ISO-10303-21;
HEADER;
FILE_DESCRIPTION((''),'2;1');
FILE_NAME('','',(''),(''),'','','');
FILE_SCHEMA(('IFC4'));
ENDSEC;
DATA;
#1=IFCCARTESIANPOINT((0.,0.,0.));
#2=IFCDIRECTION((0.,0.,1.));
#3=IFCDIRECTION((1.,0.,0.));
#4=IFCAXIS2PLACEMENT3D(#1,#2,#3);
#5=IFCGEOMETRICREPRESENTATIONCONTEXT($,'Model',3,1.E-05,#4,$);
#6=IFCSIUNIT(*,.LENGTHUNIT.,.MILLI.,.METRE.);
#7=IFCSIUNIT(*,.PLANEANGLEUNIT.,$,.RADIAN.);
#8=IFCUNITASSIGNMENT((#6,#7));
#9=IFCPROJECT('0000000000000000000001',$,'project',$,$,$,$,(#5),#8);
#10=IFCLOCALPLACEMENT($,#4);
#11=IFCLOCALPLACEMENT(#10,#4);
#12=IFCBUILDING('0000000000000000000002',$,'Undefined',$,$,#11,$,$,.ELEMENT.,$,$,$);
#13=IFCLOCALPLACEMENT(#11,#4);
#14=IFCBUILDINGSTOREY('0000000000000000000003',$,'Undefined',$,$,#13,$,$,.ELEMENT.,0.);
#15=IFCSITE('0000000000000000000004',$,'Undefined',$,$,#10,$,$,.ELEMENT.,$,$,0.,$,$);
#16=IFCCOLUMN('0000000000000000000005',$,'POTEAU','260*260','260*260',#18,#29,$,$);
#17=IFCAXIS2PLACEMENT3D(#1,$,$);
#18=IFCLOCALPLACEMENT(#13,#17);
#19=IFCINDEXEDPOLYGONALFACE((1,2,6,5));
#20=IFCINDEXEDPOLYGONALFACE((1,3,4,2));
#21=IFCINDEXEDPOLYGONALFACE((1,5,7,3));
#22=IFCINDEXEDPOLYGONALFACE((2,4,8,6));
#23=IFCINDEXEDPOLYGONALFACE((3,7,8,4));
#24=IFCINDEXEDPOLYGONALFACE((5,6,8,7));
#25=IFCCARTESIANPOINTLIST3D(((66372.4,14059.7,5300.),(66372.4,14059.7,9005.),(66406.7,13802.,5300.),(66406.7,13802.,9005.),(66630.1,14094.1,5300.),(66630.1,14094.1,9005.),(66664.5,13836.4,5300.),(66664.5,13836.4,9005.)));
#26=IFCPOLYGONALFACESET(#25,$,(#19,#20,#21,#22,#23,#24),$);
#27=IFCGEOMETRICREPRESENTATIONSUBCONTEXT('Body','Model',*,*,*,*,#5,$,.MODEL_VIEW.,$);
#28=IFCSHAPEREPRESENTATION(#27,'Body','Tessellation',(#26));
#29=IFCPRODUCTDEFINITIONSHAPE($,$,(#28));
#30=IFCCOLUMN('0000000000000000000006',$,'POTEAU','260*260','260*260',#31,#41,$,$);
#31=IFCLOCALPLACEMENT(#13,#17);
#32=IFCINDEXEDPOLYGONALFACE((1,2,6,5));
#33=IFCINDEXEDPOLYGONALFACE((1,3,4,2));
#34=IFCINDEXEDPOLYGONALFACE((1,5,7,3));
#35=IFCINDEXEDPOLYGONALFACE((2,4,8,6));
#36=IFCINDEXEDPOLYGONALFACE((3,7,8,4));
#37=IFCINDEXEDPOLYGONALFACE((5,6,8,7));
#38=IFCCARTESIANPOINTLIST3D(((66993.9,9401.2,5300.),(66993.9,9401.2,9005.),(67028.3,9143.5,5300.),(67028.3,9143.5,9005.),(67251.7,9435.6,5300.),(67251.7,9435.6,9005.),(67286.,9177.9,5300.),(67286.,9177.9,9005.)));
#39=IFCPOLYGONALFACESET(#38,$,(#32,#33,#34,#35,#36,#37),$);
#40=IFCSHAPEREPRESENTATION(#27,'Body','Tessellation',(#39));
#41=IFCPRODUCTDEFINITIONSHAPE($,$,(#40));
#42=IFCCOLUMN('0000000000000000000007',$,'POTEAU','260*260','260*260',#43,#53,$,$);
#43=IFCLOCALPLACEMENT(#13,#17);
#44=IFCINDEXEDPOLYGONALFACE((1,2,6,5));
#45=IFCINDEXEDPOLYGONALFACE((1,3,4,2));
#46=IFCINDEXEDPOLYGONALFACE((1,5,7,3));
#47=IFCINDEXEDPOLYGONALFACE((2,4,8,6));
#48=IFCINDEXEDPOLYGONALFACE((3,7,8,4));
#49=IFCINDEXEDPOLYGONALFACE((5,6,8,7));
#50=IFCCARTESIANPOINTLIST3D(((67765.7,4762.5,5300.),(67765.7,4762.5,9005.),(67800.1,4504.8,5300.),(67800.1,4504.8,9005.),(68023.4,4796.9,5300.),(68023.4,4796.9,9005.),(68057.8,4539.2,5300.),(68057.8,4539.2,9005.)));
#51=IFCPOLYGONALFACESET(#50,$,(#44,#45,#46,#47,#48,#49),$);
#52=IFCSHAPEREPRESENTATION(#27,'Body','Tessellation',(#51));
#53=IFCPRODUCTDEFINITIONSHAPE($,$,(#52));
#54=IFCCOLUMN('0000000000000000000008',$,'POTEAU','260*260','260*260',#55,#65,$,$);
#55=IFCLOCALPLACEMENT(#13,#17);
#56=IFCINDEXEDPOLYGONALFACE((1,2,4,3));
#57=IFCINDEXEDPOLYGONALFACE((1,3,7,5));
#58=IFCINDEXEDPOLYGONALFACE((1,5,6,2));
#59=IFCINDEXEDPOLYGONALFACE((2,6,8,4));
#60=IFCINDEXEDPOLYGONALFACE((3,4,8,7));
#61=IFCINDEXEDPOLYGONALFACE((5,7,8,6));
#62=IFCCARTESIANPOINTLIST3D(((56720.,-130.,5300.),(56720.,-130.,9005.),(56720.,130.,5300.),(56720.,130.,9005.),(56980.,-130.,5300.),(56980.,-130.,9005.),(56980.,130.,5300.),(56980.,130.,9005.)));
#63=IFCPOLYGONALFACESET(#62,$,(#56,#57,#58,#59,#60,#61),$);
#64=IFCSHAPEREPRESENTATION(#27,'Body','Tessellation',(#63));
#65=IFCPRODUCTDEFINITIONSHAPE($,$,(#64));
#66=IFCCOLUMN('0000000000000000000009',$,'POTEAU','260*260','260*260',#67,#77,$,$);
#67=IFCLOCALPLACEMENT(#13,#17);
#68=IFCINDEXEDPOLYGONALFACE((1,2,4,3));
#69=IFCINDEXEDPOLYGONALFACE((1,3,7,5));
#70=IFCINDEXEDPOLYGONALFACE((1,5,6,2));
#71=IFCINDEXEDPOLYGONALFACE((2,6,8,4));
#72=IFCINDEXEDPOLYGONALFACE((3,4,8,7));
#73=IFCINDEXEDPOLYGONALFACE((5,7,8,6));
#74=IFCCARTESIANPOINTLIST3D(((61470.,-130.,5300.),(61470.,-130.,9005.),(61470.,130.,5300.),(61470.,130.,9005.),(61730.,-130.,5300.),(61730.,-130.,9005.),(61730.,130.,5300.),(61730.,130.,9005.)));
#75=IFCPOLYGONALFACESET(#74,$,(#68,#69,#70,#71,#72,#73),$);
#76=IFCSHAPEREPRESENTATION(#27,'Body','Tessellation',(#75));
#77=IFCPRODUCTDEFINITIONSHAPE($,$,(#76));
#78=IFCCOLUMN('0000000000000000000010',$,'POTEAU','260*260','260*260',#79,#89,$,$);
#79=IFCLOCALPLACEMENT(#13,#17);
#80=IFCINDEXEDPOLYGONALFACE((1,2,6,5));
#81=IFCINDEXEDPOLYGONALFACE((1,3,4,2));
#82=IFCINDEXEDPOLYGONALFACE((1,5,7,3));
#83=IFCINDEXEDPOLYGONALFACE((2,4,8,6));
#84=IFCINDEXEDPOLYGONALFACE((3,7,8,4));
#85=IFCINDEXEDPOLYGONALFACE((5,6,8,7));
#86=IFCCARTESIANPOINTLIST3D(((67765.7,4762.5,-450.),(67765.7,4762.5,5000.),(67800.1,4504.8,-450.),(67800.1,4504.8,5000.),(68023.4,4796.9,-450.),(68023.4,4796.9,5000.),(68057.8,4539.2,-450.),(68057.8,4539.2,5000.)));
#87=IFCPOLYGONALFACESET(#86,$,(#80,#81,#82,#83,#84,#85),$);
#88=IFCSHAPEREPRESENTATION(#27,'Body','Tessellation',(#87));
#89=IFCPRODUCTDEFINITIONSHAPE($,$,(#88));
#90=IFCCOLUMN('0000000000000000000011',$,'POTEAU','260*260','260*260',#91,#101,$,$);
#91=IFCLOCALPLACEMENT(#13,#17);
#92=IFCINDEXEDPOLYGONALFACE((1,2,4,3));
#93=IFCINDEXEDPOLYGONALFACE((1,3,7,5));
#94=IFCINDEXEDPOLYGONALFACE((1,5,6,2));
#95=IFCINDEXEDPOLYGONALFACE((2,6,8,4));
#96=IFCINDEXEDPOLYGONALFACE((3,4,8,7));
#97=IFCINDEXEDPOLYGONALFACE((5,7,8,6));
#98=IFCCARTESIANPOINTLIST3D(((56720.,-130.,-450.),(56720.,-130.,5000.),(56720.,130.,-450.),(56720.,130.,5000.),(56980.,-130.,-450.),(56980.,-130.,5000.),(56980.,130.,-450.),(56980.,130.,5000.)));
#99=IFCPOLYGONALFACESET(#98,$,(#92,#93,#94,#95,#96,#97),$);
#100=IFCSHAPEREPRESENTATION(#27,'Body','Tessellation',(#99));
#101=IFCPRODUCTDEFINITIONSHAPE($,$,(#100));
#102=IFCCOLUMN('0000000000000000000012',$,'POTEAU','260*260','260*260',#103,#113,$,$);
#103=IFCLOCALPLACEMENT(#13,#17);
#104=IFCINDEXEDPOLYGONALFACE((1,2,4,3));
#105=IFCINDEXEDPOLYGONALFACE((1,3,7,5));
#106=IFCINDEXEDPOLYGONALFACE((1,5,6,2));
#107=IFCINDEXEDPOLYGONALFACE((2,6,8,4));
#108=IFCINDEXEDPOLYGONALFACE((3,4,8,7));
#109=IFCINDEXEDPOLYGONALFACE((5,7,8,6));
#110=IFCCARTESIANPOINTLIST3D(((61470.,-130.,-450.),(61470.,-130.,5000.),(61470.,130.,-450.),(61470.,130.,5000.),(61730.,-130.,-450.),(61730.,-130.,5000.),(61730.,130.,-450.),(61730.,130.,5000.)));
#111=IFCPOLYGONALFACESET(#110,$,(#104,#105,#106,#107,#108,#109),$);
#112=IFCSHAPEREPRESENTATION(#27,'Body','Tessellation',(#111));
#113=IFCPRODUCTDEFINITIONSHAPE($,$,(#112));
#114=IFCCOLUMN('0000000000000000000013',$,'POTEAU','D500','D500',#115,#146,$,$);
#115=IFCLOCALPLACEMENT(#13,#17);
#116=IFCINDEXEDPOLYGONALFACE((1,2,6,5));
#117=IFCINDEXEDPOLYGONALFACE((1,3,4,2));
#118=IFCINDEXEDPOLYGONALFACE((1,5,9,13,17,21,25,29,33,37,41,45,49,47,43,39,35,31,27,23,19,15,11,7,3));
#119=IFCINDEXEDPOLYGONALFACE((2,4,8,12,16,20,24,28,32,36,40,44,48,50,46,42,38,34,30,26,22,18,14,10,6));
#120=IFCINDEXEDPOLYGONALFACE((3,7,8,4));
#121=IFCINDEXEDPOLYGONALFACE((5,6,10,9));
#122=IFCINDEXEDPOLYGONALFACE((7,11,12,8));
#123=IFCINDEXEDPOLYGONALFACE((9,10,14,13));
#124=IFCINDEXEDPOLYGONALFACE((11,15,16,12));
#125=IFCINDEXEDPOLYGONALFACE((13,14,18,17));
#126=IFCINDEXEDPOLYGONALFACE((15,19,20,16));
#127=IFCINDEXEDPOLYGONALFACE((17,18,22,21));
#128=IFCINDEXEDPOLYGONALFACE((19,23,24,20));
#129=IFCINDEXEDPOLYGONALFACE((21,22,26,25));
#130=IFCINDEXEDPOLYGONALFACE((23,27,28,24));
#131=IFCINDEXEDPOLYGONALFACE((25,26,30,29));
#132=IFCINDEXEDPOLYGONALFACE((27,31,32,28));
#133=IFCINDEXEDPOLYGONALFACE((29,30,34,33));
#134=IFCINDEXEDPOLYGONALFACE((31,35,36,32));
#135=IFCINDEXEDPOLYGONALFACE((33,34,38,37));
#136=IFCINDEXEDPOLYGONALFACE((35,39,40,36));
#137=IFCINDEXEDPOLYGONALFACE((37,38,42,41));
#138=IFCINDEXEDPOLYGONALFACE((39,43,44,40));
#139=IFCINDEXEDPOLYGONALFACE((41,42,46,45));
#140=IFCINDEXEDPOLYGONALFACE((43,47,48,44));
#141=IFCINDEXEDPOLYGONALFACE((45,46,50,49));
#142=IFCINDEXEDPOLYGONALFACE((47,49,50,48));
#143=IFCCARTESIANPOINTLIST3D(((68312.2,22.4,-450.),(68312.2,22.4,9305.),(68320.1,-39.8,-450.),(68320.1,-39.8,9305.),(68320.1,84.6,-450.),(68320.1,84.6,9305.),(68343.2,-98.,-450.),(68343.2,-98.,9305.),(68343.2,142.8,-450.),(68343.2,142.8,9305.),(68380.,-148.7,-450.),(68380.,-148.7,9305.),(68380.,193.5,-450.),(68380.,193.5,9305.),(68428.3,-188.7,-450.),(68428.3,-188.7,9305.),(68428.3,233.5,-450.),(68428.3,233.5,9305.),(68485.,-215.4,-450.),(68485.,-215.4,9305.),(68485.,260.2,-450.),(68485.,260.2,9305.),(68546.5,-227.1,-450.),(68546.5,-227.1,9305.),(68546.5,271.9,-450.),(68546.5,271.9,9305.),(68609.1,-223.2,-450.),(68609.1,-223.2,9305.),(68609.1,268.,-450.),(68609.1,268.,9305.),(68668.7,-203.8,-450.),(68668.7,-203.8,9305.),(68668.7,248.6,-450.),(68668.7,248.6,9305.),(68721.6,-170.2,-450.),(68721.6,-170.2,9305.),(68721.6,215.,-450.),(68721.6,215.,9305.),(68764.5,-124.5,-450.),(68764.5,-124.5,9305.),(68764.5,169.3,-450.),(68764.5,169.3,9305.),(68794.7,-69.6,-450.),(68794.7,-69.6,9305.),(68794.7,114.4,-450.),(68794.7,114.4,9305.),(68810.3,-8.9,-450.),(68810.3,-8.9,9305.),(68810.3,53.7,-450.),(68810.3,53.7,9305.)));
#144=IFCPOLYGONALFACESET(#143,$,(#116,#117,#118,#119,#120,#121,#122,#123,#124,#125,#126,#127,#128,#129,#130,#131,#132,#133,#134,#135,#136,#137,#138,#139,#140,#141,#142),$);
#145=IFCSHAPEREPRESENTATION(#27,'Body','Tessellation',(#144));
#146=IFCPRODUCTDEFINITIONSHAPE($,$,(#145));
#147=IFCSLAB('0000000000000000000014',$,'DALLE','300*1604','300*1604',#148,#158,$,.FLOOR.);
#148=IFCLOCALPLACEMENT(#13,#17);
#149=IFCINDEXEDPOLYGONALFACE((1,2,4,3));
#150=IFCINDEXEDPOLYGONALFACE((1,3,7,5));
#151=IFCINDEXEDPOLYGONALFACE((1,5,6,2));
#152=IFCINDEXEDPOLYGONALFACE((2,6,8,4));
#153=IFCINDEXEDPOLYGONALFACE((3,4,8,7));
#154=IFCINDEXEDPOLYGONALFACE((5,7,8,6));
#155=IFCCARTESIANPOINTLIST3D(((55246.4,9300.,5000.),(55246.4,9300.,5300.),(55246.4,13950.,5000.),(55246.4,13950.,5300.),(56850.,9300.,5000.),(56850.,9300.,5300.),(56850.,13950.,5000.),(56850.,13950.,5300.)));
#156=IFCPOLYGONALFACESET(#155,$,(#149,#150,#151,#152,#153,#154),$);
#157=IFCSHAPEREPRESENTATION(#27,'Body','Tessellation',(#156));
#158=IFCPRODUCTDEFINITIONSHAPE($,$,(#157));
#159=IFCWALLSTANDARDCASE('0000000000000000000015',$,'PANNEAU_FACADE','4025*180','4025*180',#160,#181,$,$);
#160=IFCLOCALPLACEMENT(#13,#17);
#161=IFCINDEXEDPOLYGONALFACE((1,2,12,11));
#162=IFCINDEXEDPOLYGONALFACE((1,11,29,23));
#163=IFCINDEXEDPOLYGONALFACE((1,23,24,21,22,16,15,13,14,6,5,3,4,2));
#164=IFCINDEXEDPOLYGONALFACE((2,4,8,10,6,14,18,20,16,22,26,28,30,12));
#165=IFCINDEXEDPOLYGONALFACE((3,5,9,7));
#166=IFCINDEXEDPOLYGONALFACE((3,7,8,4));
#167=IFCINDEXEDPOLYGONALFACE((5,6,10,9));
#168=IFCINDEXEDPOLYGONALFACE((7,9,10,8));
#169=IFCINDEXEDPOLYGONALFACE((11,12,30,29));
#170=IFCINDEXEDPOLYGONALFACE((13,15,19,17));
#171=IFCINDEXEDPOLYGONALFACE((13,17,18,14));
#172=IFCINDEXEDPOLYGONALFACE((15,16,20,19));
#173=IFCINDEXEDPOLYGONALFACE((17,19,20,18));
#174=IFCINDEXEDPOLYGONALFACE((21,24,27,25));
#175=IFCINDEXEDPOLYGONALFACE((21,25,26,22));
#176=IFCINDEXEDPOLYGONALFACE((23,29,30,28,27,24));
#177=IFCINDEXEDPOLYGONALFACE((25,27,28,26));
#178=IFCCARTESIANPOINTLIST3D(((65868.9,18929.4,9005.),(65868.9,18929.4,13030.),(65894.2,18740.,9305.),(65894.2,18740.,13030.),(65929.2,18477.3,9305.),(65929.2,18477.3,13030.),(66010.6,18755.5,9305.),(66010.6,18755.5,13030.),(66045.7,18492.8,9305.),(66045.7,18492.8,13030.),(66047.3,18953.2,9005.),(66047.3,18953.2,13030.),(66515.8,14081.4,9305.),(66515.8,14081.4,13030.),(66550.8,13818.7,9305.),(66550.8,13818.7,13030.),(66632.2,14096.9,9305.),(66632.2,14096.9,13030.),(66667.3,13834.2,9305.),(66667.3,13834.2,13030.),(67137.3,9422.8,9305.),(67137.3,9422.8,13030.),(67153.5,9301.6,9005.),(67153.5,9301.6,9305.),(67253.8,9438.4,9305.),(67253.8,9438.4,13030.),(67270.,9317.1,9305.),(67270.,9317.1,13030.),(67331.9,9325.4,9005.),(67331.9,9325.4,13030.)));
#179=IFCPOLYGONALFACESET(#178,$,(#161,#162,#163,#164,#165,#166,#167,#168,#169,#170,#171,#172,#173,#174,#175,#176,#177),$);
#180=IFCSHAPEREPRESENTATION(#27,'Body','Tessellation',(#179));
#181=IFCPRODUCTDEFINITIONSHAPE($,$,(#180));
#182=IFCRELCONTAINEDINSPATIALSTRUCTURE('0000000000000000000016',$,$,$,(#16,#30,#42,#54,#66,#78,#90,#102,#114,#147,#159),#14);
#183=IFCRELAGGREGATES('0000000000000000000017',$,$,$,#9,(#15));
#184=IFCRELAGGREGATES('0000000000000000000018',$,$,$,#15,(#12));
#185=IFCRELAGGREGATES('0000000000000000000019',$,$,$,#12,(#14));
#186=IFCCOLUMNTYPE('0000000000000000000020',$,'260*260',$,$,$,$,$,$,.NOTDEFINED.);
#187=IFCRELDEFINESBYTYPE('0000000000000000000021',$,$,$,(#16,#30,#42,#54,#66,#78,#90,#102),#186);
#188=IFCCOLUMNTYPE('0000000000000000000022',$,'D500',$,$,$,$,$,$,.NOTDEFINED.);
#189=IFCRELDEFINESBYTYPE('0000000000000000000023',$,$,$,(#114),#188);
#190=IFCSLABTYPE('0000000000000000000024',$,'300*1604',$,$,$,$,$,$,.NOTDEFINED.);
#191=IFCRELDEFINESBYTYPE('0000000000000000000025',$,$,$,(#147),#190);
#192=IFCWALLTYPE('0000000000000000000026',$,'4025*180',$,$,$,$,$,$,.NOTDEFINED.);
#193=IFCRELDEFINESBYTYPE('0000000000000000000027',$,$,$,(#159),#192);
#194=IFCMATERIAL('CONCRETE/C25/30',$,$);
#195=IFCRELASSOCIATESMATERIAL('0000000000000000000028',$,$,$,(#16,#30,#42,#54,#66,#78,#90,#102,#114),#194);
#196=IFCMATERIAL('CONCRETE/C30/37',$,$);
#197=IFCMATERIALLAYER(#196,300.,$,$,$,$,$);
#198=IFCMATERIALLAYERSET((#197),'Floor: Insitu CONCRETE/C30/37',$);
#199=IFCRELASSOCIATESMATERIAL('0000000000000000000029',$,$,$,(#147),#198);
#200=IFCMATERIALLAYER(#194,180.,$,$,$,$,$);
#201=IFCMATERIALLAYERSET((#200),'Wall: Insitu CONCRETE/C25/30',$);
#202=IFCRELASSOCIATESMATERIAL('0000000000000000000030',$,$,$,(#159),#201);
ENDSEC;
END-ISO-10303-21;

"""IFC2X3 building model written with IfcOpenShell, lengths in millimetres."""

from ifc_helpers import new_model, si_unit, frame, frame_2d, origin_with_axes, origin_2d_with_axis, place, context, subcontext, project, spatial, polyline, rectangle, circle, outline, extrude, boolean, material, layer, layer_set, layer_usage, type_object, element, save


model = new_model("IFC2X3")

# Units and contexts
model_context = context("Model", 3, precision=1e-05, world=origin_with_axes())
body_context = subcontext(model_context, "Body", "Model", "MODEL_VIEW")
ifc_project = project(units=[si_unit("LENGTHUNIT", "METRE", prefix="MILLI"), si_unit("PLANEANGLEUNIT", "RADIAN")], contexts=[model_context])

# Site, building, storey
site_placement = place(None, origin_with_axes())
site = spatial("IfcSite", under=ifc_project, at=site_placement, Name="Undefined", CompositionType="ELEMENT", RefElevation=0.0)
building_placement = place(site_placement, origin_with_axes())
building = spatial("IfcBuilding", under=site, at=building_placement, Name="Undefined", CompositionType="ELEMENT")
storey_placement = place(building_placement, origin_with_axes())
storey = spatial("IfcBuildingStorey", under=building, at=storey_placement, Name="Undefined", CompositionType="ELEMENT", Elevation=0.0)

# Columns
ifc_material_1 = material(Name="CONCRETE/C25/30")
column_type_1 = type_object("IfcColumnType", Name="260*260", PredefinedType="NOTDEFINED")
for number, where, z_axis, x_axis, name in (
    (1, (66518.4, 13948.0, 5300.0), (0.0, 0.0, 1.0), (1.0, 0.0, 0.0), "POTEAU"),
    (2, (67140.0, 9289.5, 5300.0), (0.0, 0.0, 1.0), (1.0, 0.0, 0.0), "POTEAU"),
    (3, (67911.7, 4650.9, 5300.0), (0.0, 0.0, 1.0), (1.0, 0.0, 0.0), "POTEAU"),
):
    element("IfcColumn", number, at=place(storey_placement, frame(where, z_axis=z_axis, x_axis=x_axis)), inside=storey, type_object=column_type_1, material=ifc_material_1, Name=name, Description="260*260", ObjectType="260*260", context=body_context, shape_type="SweptSolid", body=[
        extrude(rectangle(XDim=260.0, YDim=260.0, at=origin_2d_with_axis()), frame((0.0, 0.0, 3705.0), z_axis=(0.0, 0.0, -1.0), x_axis=(0.132256, -0.991216, 0.0)), (0.0, 0.0, 1.0), 3705.0),
    ])
column_1_placement = place(storey_placement, frame((56850.0, 0.0, 5300.0), z_axis=(0.0, 0.0, 1.0), x_axis=(1.0, 0.0, 0.0)))
element("IfcColumn", 4, at=column_1_placement, inside=storey, type_object=column_type_1, material=ifc_material_1, Name="POTEAU", Description="260*260", ObjectType="260*260", context=body_context, shape_type="SweptSolid", body=[
    extrude(rectangle(XDim=260.0, YDim=260.0, at=origin_2d_with_axis()), frame((0.0, 0.0, 3705.0), z_axis=(0.0, 0.0, -1.0), x_axis=(-1.0, 0.000081, 0.0)), (0.0, 0.0, 1.0), 3705.0),
])
column_2_placement = place(storey_placement, frame((61600.0, 0.0, 5300.0), z_axis=(0.0, 0.0, 1.0), x_axis=(1.0, 0.0, 0.0)))
element("IfcColumn", 5, at=column_2_placement, inside=storey, type_object=column_type_1, material=ifc_material_1, Name="POTEAU", Description="260*260", ObjectType="260*260", context=body_context, shape_type="SweptSolid", body=[
    extrude(rectangle(XDim=260.0, YDim=260.0, at=origin_2d_with_axis()), frame((0.0, 0.0, 3705.0), z_axis=(0.0, 0.0, -1.0), x_axis=(-1.0, 0.0, 0.0)), (0.0, 0.0, 1.0), 3705.0),
])
column_3_placement = place(storey_placement, frame((67911.7, 4650.9, -450.0), z_axis=(0.0, 0.0, 1.0), x_axis=(1.0, 0.0, 0.0)))
element("IfcColumn", 6, at=column_3_placement, inside=storey, type_object=column_type_1, material=ifc_material_1, Name="POTEAU", Description="260*260", ObjectType="260*260", context=body_context, shape_type="SweptSolid", body=[
    extrude(rectangle(XDim=260.0, YDim=260.0, at=origin_2d_with_axis()), frame((0.0, 0.0, 5450.0), z_axis=(0.0, 0.0, -1.0), x_axis=(0.132256, -0.991216, 0.0)), (0.0, 0.0, 1.0), 5450.0),
])
column_4_placement = place(storey_placement, frame((56850.0, 0.0, -450.0), z_axis=(0.0, 0.0, 1.0), x_axis=(1.0, 0.0, 0.0)))
element("IfcColumn", 7, at=column_4_placement, inside=storey, type_object=column_type_1, material=ifc_material_1, Name="POTEAU", Description="260*260", ObjectType="260*260", context=body_context, shape_type="SweptSolid", body=[
    extrude(rectangle(XDim=260.0, YDim=260.0, at=origin_2d_with_axis()), frame((0.0, 0.0, 5450.0), z_axis=(0.0, 0.0, -1.0), x_axis=(-1.0, 0.0, 0.0)), (0.0, 0.0, 1.0), 5450.0),
])
column_5_placement = place(storey_placement, frame((61600.0, 0.0, -450.0), z_axis=(0.0, 0.0, 1.0), x_axis=(1.0, 0.0, 0.0)))
element("IfcColumn", 8, at=column_5_placement, inside=storey, type_object=column_type_1, material=ifc_material_1, Name="POTEAU", Description="260*260", ObjectType="260*260", context=body_context, shape_type="SweptSolid", body=[
    extrude(rectangle(XDim=260.0, YDim=260.0, at=origin_2d_with_axis()), frame((0.0, 0.0, 5450.0), z_axis=(0.0, 0.0, -1.0), x_axis=(-1.0, 0.0, 0.0)), (0.0, 0.0, 1.0), 5450.0),
])
column_type_2 = type_object("IfcColumnType", Name="D500", PredefinedType="NOTDEFINED")
column_6_placement = place(storey_placement, frame((68562.2, 22.4, -450.0), z_axis=(0.0, 0.0, 1.0), x_axis=(1.0, 0.0, 0.0)))
element("IfcColumn", 9, at=column_6_placement, inside=storey, type_object=column_type_2, material=ifc_material_1, Name="POTEAU", Description="D500", ObjectType="D500", context=body_context, shape_type="SweptSolid", body=[
    extrude(circle(Radius=250.0, at=origin_2d_with_axis()), frame((0.0, 0.0, 9755.0), z_axis=(0.0, 0.0, -1.0), x_axis=(-1.0, 0.0, 0.0)), (0.0, 0.0, 1.0), 9755.0),
])

# Slab
ifc_material_2 = material(Name="CONCRETE/C30/37")
ifc_layer_1 = layer(ifc_material_2, 300.0)
ifc_layer_set_1 = layer_set([ifc_layer_1], Name="Floor: Insitu CONCRETE/C30/37")
ifc_layer_usage_1 = layer_usage(ifc_layer_set_1, "AXIS3", "POSITIVE", -150.0)
slab_type_1 = type_object("IfcSlabType", Name="300*1604", PredefinedType="NOTDEFINED")
slab_1_placement = place(storey_placement, frame((56850.0, 13950.0, 5150.0), z_axis=(0.0, 0.0, 1.0), x_axis=(-1.0, 0.0, 0.0)))
element("IfcSlab", 10, at=slab_1_placement, inside=storey, type_object=slab_type_1, material=ifc_layer_usage_1, Name="DALLE", Description="300*1604", ObjectType="300*1604", PredefinedType="FLOOR", context=body_context, shape_type="SweptSolid", body=[
    extrude(outline(polyline([(0.0, 0.0), (1603.6, 0.0), (1603.6, 4650.0), (0.0, 4650.0), (0.0, 0.0)])), frame((0.0, 0.0, -150.0), z_axis=(0.0, 0.0, 1.0), x_axis=(1.0, 0.0, 0.0)), (0.0, 0.0, 1.0), 300.0),
])

# Wall
ifc_layer_2 = layer(ifc_material_1, 180.0)
ifc_layer_set_2 = layer_set([ifc_layer_2], Name="Wall: Insitu CONCRETE/C25/30")
ifc_layer_usage_2 = layer_usage(ifc_layer_set_2, "AXIS2", "POSITIVE", -90.0)
wall_type_1 = type_object("IfcWallType", Name="4025*180", PredefinedType="NOTDEFINED")
wall_1_placement = place(storey_placement, frame((67242.7, 9313.5, 9005.0), z_axis=(0.0, 0.0, 1.0), x_axis=(-0.132256, 0.991216, 0.0)))
element("IfcWallStandardCase", 11, at=wall_1_placement, inside=storey, type_object=wall_type_1, material=ifc_layer_usage_2, Name="PANNEAU_FACADE", Description="4025*180", ObjectType="4025*180", context=body_context, shape_type="CSG", body=[
    boolean("DIFFERENCE", boolean("DIFFERENCE", boolean("DIFFERENCE", extrude(rectangle(XDim=9713.1, YDim=180.0, at=frame_2d((0.0, 4856.6), x_axis=(0.0, -1.0))), frame((0.0, 0.0, 0.0), z_axis=(0.0, 0.0, 1.0), x_axis=(0.0, -1.0, 0.0)), (0.0, 0.0, 1.0), 4025.0), extrude(rectangle(XDim=265.0, YDim=265.0, at=origin_2d_with_axis()), frame((-10.1, 105.0, 4025.0), z_axis=(0.0, 0.0, -1.0), x_axis=(-1.0, 0.0, 0.0)), (0.0, 0.0, 1.0), 3725.0)), extrude(rectangle(XDim=265.0, YDim=265.0, at=origin_2d_with_axis()), frame((4689.7, 105.0, 4025.0), z_axis=(0.0, 0.0, -1.0), x_axis=(-1.0, 0.0, 0.0)), (0.0, 0.0, 1.0), 3725.0)), extrude(rectangle(XDim=265.0, YDim=265.0, at=origin_2d_with_axis()), frame((9389.6, 105.0, 4025.0), z_axis=(0.0, 0.0, -1.0), x_axis=(-1.0, 0.0, 0.0)), (0.0, 0.0, 1.0), 3725.0)),
])

save(model, "model.ifc")
